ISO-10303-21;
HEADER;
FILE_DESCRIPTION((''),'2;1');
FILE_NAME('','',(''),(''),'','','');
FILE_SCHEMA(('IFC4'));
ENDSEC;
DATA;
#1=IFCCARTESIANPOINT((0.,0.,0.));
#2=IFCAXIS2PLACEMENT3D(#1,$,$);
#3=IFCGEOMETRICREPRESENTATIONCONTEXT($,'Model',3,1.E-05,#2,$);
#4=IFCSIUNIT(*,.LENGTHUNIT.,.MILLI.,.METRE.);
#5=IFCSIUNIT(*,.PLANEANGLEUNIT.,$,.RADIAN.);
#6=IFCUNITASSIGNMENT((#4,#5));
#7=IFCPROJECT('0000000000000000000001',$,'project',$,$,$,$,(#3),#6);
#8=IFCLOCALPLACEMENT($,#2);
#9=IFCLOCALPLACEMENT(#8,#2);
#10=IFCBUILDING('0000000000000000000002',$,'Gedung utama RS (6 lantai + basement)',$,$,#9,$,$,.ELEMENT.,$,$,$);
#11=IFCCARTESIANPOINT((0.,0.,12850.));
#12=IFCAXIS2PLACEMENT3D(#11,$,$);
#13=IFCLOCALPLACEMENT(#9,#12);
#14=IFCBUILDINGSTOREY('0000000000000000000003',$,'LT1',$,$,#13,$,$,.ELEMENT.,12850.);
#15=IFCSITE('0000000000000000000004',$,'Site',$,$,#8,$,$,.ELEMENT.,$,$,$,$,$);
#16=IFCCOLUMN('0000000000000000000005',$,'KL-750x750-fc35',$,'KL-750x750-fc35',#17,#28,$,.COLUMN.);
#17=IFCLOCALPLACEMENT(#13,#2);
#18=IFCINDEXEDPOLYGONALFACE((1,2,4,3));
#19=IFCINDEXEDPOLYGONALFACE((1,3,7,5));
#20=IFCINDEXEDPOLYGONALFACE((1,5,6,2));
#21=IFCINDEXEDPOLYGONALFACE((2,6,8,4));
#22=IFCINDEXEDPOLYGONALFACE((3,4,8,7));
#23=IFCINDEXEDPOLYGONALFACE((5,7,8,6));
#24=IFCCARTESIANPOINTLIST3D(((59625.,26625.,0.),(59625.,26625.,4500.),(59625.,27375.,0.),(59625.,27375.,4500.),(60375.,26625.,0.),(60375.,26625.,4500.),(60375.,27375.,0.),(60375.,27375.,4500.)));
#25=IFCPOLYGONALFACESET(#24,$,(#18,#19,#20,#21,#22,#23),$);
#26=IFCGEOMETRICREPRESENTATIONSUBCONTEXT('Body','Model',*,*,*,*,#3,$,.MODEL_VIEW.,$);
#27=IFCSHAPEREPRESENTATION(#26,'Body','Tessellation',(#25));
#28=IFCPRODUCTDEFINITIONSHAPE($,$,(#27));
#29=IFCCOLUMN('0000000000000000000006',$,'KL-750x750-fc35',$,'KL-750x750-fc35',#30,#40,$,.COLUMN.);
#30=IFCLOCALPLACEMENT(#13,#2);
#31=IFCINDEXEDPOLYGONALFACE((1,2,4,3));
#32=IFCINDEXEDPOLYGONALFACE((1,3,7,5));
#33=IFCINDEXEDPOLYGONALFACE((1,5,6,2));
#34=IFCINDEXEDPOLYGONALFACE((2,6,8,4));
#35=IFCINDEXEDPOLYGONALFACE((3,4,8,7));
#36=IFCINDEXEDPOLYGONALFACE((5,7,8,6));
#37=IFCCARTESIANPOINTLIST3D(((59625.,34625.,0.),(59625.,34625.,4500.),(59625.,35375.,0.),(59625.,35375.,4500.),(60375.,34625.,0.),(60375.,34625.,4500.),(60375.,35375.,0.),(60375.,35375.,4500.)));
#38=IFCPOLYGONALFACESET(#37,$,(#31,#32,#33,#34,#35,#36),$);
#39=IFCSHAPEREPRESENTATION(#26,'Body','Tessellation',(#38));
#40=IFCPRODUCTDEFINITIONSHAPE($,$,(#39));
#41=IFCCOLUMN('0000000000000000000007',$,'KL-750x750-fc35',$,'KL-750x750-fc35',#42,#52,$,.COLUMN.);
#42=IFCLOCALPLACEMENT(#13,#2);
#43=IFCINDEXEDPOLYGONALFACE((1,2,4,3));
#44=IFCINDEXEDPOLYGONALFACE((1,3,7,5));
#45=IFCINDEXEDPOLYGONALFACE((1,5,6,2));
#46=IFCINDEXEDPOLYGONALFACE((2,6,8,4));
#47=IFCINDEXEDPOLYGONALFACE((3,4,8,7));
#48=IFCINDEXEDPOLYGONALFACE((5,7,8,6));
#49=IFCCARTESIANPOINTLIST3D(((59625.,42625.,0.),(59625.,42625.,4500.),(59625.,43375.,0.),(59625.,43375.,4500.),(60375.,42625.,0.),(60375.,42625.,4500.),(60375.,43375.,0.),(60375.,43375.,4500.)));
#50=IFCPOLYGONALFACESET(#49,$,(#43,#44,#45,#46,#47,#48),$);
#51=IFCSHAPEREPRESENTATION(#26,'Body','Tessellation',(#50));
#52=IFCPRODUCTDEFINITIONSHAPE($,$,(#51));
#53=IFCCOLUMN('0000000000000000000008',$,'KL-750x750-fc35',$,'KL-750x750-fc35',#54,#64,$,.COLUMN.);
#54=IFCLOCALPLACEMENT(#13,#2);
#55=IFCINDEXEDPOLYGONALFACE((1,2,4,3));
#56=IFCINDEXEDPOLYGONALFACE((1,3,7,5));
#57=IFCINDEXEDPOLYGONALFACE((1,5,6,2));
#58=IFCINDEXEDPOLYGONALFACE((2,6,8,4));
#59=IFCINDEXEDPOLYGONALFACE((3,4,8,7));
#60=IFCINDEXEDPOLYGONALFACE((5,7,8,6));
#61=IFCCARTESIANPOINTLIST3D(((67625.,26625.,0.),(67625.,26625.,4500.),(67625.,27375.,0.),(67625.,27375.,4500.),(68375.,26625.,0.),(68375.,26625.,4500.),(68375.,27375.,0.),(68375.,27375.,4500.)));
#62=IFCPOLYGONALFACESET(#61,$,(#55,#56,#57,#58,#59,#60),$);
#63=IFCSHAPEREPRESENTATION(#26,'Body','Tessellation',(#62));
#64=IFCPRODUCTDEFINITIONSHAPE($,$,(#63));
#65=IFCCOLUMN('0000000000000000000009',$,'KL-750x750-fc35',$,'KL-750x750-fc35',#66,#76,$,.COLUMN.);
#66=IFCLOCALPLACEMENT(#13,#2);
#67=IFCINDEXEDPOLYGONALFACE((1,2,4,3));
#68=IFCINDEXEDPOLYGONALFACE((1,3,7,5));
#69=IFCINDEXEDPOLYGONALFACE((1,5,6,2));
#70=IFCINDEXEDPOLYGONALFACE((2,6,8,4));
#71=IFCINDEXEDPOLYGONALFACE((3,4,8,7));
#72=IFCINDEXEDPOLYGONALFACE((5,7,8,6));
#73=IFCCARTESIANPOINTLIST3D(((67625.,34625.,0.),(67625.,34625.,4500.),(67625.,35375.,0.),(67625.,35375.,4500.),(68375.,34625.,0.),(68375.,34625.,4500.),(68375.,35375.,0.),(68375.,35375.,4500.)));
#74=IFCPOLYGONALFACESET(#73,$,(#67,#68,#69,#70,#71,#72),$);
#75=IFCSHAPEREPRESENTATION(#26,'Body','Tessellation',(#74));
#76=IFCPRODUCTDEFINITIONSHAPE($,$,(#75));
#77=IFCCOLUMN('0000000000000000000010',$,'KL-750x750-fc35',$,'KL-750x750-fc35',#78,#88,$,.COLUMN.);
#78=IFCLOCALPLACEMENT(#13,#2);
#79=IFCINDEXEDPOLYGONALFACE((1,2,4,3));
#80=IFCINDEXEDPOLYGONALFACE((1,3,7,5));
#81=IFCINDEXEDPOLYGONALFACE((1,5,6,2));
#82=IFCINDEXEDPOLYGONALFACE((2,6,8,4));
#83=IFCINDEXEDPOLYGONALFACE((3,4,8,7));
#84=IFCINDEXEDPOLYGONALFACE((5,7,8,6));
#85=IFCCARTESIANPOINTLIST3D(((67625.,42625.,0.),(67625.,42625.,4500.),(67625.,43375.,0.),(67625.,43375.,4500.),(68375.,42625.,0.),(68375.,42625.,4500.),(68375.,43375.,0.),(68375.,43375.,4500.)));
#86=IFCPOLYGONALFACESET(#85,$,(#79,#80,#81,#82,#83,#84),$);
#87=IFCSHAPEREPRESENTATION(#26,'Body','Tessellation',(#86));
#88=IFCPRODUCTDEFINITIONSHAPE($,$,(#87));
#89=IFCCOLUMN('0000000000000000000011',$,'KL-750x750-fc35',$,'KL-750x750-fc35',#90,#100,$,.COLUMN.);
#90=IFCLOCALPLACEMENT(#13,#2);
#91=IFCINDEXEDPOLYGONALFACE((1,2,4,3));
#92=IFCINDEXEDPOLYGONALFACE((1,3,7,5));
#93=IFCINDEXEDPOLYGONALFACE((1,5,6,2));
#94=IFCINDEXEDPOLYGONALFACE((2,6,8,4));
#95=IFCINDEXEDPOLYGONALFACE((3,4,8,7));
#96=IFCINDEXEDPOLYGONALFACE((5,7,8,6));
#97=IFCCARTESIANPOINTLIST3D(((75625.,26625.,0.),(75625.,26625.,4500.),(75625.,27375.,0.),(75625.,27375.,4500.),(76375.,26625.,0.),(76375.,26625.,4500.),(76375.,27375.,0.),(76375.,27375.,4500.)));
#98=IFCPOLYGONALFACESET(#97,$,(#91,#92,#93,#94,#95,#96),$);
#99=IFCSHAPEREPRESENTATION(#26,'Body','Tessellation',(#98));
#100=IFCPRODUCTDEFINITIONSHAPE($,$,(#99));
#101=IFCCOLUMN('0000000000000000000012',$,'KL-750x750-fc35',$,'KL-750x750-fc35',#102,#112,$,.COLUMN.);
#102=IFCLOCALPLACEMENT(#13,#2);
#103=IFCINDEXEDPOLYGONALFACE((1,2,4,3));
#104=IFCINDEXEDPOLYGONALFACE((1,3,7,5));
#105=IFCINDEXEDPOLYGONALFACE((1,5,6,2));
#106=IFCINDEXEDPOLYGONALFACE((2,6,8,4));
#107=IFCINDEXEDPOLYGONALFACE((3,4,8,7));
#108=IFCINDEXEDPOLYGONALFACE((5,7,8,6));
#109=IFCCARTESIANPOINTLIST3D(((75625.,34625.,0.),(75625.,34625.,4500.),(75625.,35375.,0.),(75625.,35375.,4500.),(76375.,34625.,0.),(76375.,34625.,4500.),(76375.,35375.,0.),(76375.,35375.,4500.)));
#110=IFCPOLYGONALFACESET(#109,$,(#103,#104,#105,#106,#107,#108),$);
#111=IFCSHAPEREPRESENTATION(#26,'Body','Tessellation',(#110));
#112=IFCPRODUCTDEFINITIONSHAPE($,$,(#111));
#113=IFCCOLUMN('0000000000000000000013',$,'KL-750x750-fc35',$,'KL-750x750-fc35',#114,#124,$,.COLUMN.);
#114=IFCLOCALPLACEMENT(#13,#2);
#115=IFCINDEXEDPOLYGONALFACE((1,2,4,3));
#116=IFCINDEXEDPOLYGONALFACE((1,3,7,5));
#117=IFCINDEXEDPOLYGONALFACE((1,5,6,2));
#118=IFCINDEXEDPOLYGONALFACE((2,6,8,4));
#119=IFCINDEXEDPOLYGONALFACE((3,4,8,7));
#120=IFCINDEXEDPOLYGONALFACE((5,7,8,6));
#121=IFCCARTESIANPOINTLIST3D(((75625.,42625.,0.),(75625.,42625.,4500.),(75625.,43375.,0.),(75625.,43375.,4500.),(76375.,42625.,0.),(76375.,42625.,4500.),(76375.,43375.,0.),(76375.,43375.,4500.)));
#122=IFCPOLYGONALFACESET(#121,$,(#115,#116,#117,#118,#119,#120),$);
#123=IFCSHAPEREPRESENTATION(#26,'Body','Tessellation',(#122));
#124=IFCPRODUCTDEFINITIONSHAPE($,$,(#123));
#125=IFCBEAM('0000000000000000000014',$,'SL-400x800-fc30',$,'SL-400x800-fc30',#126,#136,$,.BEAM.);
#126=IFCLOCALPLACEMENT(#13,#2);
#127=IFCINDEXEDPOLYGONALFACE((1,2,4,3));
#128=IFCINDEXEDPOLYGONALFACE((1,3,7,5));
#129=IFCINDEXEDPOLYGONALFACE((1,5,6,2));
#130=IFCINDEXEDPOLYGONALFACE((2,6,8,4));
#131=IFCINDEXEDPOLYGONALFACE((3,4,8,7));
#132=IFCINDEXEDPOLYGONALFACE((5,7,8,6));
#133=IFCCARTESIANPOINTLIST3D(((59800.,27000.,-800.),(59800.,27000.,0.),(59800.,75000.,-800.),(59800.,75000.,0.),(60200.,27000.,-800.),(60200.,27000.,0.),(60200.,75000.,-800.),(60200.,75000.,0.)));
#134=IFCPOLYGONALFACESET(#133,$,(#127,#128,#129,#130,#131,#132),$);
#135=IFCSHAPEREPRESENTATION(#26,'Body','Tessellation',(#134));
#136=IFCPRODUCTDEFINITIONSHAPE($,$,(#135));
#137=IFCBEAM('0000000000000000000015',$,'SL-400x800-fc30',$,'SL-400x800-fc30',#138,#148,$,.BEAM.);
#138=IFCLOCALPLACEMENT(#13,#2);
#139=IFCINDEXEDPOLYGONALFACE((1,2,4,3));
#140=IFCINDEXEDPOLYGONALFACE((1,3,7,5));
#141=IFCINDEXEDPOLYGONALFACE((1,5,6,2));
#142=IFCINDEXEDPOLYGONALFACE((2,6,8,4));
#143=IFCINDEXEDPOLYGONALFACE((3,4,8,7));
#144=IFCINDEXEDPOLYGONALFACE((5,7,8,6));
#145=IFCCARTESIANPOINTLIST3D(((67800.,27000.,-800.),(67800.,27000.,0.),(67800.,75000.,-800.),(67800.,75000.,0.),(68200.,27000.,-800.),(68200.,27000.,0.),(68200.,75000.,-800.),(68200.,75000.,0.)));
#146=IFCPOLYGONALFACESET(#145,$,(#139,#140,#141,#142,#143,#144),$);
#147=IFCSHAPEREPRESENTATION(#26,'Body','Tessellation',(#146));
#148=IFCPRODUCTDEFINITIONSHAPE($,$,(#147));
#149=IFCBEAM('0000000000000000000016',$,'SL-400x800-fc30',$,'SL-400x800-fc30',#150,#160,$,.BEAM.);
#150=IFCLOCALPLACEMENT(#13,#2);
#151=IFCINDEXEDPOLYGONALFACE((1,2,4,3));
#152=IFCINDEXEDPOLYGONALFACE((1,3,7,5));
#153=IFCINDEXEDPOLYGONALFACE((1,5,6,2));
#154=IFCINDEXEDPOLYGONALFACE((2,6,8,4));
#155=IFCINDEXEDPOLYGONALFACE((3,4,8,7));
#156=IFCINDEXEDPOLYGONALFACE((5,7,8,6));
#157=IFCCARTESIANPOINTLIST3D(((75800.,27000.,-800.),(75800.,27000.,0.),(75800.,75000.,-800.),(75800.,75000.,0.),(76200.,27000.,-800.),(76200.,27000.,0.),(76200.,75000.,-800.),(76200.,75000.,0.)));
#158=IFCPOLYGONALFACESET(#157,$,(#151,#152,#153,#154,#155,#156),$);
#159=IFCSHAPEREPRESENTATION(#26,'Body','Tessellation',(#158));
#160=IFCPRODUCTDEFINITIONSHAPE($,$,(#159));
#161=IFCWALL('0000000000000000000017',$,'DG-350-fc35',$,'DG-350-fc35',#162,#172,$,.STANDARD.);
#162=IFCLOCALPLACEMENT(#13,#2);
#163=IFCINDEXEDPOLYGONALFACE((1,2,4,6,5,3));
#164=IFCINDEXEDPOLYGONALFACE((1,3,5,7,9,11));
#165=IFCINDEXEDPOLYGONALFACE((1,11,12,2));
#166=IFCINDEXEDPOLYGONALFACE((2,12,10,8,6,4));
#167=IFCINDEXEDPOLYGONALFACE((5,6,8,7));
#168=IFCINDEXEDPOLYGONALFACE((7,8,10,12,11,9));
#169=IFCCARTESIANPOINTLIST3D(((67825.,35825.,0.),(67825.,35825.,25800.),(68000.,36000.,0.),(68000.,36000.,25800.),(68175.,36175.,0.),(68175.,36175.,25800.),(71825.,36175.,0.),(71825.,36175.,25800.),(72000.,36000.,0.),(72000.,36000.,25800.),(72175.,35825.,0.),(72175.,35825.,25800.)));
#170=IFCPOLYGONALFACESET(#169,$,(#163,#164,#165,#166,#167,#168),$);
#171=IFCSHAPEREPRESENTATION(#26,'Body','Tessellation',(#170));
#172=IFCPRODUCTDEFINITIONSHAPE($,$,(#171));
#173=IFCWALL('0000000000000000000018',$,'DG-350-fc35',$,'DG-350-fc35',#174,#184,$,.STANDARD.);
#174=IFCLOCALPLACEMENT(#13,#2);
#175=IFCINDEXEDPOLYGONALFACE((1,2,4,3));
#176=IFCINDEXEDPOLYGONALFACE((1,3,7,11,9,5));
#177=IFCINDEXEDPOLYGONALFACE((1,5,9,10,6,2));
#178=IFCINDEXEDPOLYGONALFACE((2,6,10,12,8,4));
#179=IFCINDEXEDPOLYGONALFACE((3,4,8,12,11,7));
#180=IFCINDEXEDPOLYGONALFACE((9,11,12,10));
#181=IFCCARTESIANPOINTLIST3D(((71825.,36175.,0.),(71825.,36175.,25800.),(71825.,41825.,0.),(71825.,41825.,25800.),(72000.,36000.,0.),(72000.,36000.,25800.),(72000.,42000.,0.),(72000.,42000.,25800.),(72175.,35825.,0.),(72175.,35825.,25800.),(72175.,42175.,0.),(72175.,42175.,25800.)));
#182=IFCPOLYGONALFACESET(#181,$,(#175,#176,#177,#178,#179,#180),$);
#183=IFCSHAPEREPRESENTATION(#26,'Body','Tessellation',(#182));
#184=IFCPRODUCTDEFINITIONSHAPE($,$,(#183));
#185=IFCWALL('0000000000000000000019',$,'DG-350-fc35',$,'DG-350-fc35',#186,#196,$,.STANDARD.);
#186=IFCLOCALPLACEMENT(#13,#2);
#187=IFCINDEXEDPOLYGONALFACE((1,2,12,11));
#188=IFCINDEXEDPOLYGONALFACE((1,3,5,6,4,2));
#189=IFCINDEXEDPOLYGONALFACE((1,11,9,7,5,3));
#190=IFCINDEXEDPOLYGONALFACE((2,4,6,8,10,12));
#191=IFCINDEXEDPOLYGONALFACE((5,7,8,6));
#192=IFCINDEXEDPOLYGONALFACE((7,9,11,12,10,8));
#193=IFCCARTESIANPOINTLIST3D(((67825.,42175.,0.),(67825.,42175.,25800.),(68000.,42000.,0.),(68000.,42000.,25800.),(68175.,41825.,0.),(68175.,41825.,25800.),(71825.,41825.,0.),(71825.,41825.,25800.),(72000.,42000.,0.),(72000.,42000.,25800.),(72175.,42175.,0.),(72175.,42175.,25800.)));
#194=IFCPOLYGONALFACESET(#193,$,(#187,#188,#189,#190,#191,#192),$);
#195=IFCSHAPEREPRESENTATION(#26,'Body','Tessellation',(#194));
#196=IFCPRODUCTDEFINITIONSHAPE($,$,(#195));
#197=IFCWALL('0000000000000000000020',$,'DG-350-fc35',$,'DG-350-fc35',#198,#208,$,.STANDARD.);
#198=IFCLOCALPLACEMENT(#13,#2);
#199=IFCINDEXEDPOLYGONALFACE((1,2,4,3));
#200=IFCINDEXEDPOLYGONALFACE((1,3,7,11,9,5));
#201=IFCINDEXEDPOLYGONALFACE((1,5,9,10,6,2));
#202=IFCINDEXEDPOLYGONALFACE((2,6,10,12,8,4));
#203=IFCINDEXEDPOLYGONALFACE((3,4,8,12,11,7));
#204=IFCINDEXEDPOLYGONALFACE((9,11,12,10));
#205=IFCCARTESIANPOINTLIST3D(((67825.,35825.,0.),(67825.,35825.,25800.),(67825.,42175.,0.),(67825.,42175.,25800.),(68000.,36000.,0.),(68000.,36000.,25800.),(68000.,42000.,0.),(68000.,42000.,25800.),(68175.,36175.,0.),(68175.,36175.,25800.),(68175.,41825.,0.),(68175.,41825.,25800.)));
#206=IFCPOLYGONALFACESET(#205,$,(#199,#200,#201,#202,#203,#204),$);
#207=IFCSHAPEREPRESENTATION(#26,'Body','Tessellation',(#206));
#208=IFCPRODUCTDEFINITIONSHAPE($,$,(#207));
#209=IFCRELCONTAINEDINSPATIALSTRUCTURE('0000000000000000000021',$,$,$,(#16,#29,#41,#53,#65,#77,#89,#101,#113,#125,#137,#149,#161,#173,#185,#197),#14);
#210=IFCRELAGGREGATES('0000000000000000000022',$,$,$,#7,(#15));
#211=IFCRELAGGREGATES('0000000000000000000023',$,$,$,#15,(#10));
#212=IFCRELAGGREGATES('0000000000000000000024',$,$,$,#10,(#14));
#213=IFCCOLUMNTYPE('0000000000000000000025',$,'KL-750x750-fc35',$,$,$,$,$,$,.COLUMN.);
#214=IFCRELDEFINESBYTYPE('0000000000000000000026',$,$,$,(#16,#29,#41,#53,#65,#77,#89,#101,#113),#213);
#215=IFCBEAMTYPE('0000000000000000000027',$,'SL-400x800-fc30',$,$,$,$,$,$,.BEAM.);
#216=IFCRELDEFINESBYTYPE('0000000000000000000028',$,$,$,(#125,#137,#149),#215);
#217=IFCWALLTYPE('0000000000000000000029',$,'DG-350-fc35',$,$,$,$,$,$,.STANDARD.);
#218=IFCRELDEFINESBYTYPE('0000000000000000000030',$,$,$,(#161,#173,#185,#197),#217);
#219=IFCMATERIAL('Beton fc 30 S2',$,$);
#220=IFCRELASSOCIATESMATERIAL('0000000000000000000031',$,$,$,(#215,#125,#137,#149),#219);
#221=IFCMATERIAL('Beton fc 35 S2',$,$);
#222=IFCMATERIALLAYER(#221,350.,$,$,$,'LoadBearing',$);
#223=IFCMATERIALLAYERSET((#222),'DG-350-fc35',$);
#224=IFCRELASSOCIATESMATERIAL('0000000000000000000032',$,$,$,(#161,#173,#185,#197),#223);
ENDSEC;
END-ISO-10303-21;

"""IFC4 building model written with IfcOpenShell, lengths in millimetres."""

from ifc_helpers import new_model, si_unit, frame, origin, origin_2d, place, context, subcontext, project, spatial, polyline, rectangle, outline, extrude, material, layer, layer_set, layer_usage, material_profile, profile_set, profile_usage, type_object, element, save


model = new_model("IFC4")

# Units and contexts
model_context = context("Model", 3, precision=1e-05, world=origin())
body_context = subcontext(model_context, "Body", "Model", "MODEL_VIEW")
ifc_project = project(units=[si_unit("LENGTHUNIT", "METRE", prefix="MILLI"), si_unit("PLANEANGLEUNIT", "RADIAN")], contexts=[model_context])

# Site, building, storey
site_placement = place(None, origin())
site = spatial("IfcSite", under=ifc_project, at=site_placement, Name="Site", CompositionType="ELEMENT")
building_placement = place(site_placement, origin())
building = spatial("IfcBuilding", under=site, at=building_placement, Name="Gedung utama RS (6 lantai + basement)", CompositionType="ELEMENT")
storey_placement = place(building_placement, frame((0.0, 0.0, 12850.0)))
storey = spatial("IfcBuildingStorey", under=building, at=storey_placement, Name="LT1", CompositionType="ELEMENT", Elevation=12850.0)

# Columns
ifc_material_profile_1 = material_profile(None, rectangle(XDim=750.0, YDim=750.0, at=origin_2d()), Name="KL-750x750-fc35")
ifc_profile_set_1 = profile_set([ifc_material_profile_1], Name="KL-750x750-fc35")
ifc_profile_usage_1 = profile_usage(ifc_profile_set_1, cardinal=5)
column_type = type_object("IfcColumnType", Name="KL-750x750-fc35", PredefinedType="COLUMN", material=ifc_profile_set_1)
for number, where, z_axis, x_axis, name in (
    (1, (60000.0, 27000.0, 0.0), (0.0, 0.0, 1.0), (1.0, 0.0, 0.0), "KL-750x750-fc35"),
    (2, (60000.0, 35000.0, 0.0), (0.0, 0.0, 1.0), (1.0, 0.0, 0.0), "KL-750x750-fc35"),
    (3, (60000.0, 43000.0, 0.0), (0.0, 0.0, 1.0), (1.0, 0.0, 0.0), "KL-750x750-fc35"),
    (4, (68000.0, 27000.0, 0.0), (0.0, 0.0, 1.0), (1.0, 0.0, 0.0), "KL-750x750-fc35"),
    (5, (68000.0, 35000.0, 0.0), (0.0, 0.0, 1.0), (1.0, 0.0, 0.0), "KL-750x750-fc35"),
    (6, (68000.0, 43000.0, 0.0), (0.0, 0.0, 1.0), (1.0, 0.0, 0.0), "KL-750x750-fc35"),
    (7, (76000.0, 27000.0, 0.0), (0.0, 0.0, 1.0), (1.0, 0.0, 0.0), "KL-750x750-fc35"),
    (8, (76000.0, 35000.0, 0.0), (0.0, 0.0, 1.0), (1.0, 0.0, 0.0), "KL-750x750-fc35"),
    (9, (76000.0, 43000.0, 0.0), (0.0, 0.0, 1.0), (1.0, 0.0, 0.0), "KL-750x750-fc35"),
):
    element("IfcColumn", number, at=place(storey_placement, frame(where, z_axis=z_axis, x_axis=x_axis)), inside=storey, type_object=column_type, material=ifc_profile_usage_1, Name=name, ObjectType="KL-750x750-fc35", PredefinedType="COLUMN", context=body_context, shape_type="SweptSolid", body=[
        extrude(rectangle(XDim=750.0, YDim=750.0, at=origin_2d()), origin(), (0.0, 0.0, 1.0), 4500.0),
    ])

# Beams
ifc_material_1 = material(Name="Beton fc 30 S2")
ifc_material_profile_2 = material_profile(ifc_material_1, rectangle(XDim=400.0, YDim=800.0, at=origin_2d()), Name="SL-400x800-fc30")
ifc_profile_set_2 = profile_set([ifc_material_profile_2], Name="SL-400x800-fc30")
ifc_profile_usage_2 = profile_usage(ifc_profile_set_2, cardinal=8)
beam_type = type_object("IfcBeamType", Name="SL-400x800-fc30", PredefinedType="BEAM", material=ifc_profile_set_2)
for number, where, name in (
    (10, (60000.0, 27000.0, -400.0), "SL-400x800-fc30"),
    (11, (68000.0, 27000.0, -400.0), "SL-400x800-fc30"),
    (12, (76000.0, 27000.0, -400.0), "SL-400x800-fc30"),
):
    element("IfcBeam", number, at=place(storey_placement, frame(where)), inside=storey, type_object=beam_type, material=ifc_profile_usage_2, Name=name, ObjectType="SL-400x800-fc30", PredefinedType="BEAM", context=body_context, shape_type="SweptSolid", body=[
        extrude(rectangle(XDim=400.0, YDim=800.0, at=origin_2d()), frame((0.0, 0.0, 0.0), z_axis=(0.0, 1.0, 0.0), x_axis=(-1.0, 0.0, 0.0)), (0.0, 0.0, 1.0), 48000.0),
    ])

# Walls
ifc_material_2 = material(Name="Beton fc 35 S2")
ifc_layer = layer(ifc_material_2, 350.0, Category="LoadBearing")
ifc_layer_set = layer_set([ifc_layer], Name="DG-350-fc35")
ifc_layer_usage = layer_usage(ifc_layer_set, "AXIS2", "NEGATIVE", 175.0)
wall_type = type_object("IfcWallType", Name="DG-350-fc35", PredefinedType="STANDARD")
wall_1_placement = place(storey_placement, frame((68000.0, 36000.0, 0.0), z_axis=(0.0, 0.0, 1.0), x_axis=(1.0, 0.0, 0.0)))
element("IfcWall", 13, at=wall_1_placement, inside=storey, type_object=wall_type, material=ifc_layer_usage, Name="DG-350-fc35", ObjectType="DG-350-fc35", PredefinedType="STANDARD", context=body_context, shape_type="SweptSolid", body=[
    extrude(outline(polyline([(-175.0, -175.0), (0.0, 0.0), (175.0, 175.0), (3825.0, 175.0), (4000.0, 0.0), (4175.0, -175.0), (-175.0, -175.0)])), origin(), (0.0, 0.0, 1.0), 25800.0),
])
wall_2_placement = place(storey_placement, frame((72000.0, 36000.0, 0.0), z_axis=(0.0, 0.0, 1.0), x_axis=(0.0, 1.0, 0.0)))
element("IfcWall", 14, at=wall_2_placement, inside=storey, type_object=wall_type, material=ifc_layer_usage, Name="DG-350-fc35", ObjectType="DG-350-fc35", PredefinedType="STANDARD", context=body_context, shape_type="SweptSolid", body=[
    extrude(outline(polyline([(-175.0, -175.0), (0.0, 0.0), (175.0, 175.0), (5825.0, 175.0), (6000.0, 0.0), (6175.0, -175.0), (-175.0, -175.0)])), origin(), (0.0, 0.0, 1.0), 25800.0),
])
wall_3_placement = place(storey_placement, frame((72000.0, 42000.0, 0.0), z_axis=(0.0, 0.0, 1.0), x_axis=(-1.0, 0.0, 0.0)))
element("IfcWall", 15, at=wall_3_placement, inside=storey, type_object=wall_type, material=ifc_layer_usage, Name="DG-350-fc35", ObjectType="DG-350-fc35", PredefinedType="STANDARD", context=body_context, shape_type="SweptSolid", body=[
    extrude(outline(polyline([(-175.0, -175.0), (0.0, 0.0), (175.0, 175.0), (3825.0, 175.0), (4000.0, 0.0), (4175.0, -175.0), (-175.0, -175.0)])), origin(), (0.0, 0.0, 1.0), 25800.0),
])
wall_4_placement = place(storey_placement, frame((68000.0, 42000.0, 0.0), z_axis=(0.0, 0.0, 1.0), x_axis=(0.0, -1.0, 0.0)))
element("IfcWall", 16, at=wall_4_placement, inside=storey, type_object=wall_type, material=ifc_layer_usage, Name="DG-350-fc35", ObjectType="DG-350-fc35", PredefinedType="STANDARD", context=body_context, shape_type="SweptSolid", body=[
    extrude(outline(polyline([(-175.0, -175.0), (0.0, 0.0), (175.0, 175.0), (5825.0, 175.0), (6000.0, 0.0), (6175.0, -175.0), (-175.0, -175.0)])), origin(), (0.0, 0.0, 1.0), 25800.0),
])

save(model, "model.ifc")
